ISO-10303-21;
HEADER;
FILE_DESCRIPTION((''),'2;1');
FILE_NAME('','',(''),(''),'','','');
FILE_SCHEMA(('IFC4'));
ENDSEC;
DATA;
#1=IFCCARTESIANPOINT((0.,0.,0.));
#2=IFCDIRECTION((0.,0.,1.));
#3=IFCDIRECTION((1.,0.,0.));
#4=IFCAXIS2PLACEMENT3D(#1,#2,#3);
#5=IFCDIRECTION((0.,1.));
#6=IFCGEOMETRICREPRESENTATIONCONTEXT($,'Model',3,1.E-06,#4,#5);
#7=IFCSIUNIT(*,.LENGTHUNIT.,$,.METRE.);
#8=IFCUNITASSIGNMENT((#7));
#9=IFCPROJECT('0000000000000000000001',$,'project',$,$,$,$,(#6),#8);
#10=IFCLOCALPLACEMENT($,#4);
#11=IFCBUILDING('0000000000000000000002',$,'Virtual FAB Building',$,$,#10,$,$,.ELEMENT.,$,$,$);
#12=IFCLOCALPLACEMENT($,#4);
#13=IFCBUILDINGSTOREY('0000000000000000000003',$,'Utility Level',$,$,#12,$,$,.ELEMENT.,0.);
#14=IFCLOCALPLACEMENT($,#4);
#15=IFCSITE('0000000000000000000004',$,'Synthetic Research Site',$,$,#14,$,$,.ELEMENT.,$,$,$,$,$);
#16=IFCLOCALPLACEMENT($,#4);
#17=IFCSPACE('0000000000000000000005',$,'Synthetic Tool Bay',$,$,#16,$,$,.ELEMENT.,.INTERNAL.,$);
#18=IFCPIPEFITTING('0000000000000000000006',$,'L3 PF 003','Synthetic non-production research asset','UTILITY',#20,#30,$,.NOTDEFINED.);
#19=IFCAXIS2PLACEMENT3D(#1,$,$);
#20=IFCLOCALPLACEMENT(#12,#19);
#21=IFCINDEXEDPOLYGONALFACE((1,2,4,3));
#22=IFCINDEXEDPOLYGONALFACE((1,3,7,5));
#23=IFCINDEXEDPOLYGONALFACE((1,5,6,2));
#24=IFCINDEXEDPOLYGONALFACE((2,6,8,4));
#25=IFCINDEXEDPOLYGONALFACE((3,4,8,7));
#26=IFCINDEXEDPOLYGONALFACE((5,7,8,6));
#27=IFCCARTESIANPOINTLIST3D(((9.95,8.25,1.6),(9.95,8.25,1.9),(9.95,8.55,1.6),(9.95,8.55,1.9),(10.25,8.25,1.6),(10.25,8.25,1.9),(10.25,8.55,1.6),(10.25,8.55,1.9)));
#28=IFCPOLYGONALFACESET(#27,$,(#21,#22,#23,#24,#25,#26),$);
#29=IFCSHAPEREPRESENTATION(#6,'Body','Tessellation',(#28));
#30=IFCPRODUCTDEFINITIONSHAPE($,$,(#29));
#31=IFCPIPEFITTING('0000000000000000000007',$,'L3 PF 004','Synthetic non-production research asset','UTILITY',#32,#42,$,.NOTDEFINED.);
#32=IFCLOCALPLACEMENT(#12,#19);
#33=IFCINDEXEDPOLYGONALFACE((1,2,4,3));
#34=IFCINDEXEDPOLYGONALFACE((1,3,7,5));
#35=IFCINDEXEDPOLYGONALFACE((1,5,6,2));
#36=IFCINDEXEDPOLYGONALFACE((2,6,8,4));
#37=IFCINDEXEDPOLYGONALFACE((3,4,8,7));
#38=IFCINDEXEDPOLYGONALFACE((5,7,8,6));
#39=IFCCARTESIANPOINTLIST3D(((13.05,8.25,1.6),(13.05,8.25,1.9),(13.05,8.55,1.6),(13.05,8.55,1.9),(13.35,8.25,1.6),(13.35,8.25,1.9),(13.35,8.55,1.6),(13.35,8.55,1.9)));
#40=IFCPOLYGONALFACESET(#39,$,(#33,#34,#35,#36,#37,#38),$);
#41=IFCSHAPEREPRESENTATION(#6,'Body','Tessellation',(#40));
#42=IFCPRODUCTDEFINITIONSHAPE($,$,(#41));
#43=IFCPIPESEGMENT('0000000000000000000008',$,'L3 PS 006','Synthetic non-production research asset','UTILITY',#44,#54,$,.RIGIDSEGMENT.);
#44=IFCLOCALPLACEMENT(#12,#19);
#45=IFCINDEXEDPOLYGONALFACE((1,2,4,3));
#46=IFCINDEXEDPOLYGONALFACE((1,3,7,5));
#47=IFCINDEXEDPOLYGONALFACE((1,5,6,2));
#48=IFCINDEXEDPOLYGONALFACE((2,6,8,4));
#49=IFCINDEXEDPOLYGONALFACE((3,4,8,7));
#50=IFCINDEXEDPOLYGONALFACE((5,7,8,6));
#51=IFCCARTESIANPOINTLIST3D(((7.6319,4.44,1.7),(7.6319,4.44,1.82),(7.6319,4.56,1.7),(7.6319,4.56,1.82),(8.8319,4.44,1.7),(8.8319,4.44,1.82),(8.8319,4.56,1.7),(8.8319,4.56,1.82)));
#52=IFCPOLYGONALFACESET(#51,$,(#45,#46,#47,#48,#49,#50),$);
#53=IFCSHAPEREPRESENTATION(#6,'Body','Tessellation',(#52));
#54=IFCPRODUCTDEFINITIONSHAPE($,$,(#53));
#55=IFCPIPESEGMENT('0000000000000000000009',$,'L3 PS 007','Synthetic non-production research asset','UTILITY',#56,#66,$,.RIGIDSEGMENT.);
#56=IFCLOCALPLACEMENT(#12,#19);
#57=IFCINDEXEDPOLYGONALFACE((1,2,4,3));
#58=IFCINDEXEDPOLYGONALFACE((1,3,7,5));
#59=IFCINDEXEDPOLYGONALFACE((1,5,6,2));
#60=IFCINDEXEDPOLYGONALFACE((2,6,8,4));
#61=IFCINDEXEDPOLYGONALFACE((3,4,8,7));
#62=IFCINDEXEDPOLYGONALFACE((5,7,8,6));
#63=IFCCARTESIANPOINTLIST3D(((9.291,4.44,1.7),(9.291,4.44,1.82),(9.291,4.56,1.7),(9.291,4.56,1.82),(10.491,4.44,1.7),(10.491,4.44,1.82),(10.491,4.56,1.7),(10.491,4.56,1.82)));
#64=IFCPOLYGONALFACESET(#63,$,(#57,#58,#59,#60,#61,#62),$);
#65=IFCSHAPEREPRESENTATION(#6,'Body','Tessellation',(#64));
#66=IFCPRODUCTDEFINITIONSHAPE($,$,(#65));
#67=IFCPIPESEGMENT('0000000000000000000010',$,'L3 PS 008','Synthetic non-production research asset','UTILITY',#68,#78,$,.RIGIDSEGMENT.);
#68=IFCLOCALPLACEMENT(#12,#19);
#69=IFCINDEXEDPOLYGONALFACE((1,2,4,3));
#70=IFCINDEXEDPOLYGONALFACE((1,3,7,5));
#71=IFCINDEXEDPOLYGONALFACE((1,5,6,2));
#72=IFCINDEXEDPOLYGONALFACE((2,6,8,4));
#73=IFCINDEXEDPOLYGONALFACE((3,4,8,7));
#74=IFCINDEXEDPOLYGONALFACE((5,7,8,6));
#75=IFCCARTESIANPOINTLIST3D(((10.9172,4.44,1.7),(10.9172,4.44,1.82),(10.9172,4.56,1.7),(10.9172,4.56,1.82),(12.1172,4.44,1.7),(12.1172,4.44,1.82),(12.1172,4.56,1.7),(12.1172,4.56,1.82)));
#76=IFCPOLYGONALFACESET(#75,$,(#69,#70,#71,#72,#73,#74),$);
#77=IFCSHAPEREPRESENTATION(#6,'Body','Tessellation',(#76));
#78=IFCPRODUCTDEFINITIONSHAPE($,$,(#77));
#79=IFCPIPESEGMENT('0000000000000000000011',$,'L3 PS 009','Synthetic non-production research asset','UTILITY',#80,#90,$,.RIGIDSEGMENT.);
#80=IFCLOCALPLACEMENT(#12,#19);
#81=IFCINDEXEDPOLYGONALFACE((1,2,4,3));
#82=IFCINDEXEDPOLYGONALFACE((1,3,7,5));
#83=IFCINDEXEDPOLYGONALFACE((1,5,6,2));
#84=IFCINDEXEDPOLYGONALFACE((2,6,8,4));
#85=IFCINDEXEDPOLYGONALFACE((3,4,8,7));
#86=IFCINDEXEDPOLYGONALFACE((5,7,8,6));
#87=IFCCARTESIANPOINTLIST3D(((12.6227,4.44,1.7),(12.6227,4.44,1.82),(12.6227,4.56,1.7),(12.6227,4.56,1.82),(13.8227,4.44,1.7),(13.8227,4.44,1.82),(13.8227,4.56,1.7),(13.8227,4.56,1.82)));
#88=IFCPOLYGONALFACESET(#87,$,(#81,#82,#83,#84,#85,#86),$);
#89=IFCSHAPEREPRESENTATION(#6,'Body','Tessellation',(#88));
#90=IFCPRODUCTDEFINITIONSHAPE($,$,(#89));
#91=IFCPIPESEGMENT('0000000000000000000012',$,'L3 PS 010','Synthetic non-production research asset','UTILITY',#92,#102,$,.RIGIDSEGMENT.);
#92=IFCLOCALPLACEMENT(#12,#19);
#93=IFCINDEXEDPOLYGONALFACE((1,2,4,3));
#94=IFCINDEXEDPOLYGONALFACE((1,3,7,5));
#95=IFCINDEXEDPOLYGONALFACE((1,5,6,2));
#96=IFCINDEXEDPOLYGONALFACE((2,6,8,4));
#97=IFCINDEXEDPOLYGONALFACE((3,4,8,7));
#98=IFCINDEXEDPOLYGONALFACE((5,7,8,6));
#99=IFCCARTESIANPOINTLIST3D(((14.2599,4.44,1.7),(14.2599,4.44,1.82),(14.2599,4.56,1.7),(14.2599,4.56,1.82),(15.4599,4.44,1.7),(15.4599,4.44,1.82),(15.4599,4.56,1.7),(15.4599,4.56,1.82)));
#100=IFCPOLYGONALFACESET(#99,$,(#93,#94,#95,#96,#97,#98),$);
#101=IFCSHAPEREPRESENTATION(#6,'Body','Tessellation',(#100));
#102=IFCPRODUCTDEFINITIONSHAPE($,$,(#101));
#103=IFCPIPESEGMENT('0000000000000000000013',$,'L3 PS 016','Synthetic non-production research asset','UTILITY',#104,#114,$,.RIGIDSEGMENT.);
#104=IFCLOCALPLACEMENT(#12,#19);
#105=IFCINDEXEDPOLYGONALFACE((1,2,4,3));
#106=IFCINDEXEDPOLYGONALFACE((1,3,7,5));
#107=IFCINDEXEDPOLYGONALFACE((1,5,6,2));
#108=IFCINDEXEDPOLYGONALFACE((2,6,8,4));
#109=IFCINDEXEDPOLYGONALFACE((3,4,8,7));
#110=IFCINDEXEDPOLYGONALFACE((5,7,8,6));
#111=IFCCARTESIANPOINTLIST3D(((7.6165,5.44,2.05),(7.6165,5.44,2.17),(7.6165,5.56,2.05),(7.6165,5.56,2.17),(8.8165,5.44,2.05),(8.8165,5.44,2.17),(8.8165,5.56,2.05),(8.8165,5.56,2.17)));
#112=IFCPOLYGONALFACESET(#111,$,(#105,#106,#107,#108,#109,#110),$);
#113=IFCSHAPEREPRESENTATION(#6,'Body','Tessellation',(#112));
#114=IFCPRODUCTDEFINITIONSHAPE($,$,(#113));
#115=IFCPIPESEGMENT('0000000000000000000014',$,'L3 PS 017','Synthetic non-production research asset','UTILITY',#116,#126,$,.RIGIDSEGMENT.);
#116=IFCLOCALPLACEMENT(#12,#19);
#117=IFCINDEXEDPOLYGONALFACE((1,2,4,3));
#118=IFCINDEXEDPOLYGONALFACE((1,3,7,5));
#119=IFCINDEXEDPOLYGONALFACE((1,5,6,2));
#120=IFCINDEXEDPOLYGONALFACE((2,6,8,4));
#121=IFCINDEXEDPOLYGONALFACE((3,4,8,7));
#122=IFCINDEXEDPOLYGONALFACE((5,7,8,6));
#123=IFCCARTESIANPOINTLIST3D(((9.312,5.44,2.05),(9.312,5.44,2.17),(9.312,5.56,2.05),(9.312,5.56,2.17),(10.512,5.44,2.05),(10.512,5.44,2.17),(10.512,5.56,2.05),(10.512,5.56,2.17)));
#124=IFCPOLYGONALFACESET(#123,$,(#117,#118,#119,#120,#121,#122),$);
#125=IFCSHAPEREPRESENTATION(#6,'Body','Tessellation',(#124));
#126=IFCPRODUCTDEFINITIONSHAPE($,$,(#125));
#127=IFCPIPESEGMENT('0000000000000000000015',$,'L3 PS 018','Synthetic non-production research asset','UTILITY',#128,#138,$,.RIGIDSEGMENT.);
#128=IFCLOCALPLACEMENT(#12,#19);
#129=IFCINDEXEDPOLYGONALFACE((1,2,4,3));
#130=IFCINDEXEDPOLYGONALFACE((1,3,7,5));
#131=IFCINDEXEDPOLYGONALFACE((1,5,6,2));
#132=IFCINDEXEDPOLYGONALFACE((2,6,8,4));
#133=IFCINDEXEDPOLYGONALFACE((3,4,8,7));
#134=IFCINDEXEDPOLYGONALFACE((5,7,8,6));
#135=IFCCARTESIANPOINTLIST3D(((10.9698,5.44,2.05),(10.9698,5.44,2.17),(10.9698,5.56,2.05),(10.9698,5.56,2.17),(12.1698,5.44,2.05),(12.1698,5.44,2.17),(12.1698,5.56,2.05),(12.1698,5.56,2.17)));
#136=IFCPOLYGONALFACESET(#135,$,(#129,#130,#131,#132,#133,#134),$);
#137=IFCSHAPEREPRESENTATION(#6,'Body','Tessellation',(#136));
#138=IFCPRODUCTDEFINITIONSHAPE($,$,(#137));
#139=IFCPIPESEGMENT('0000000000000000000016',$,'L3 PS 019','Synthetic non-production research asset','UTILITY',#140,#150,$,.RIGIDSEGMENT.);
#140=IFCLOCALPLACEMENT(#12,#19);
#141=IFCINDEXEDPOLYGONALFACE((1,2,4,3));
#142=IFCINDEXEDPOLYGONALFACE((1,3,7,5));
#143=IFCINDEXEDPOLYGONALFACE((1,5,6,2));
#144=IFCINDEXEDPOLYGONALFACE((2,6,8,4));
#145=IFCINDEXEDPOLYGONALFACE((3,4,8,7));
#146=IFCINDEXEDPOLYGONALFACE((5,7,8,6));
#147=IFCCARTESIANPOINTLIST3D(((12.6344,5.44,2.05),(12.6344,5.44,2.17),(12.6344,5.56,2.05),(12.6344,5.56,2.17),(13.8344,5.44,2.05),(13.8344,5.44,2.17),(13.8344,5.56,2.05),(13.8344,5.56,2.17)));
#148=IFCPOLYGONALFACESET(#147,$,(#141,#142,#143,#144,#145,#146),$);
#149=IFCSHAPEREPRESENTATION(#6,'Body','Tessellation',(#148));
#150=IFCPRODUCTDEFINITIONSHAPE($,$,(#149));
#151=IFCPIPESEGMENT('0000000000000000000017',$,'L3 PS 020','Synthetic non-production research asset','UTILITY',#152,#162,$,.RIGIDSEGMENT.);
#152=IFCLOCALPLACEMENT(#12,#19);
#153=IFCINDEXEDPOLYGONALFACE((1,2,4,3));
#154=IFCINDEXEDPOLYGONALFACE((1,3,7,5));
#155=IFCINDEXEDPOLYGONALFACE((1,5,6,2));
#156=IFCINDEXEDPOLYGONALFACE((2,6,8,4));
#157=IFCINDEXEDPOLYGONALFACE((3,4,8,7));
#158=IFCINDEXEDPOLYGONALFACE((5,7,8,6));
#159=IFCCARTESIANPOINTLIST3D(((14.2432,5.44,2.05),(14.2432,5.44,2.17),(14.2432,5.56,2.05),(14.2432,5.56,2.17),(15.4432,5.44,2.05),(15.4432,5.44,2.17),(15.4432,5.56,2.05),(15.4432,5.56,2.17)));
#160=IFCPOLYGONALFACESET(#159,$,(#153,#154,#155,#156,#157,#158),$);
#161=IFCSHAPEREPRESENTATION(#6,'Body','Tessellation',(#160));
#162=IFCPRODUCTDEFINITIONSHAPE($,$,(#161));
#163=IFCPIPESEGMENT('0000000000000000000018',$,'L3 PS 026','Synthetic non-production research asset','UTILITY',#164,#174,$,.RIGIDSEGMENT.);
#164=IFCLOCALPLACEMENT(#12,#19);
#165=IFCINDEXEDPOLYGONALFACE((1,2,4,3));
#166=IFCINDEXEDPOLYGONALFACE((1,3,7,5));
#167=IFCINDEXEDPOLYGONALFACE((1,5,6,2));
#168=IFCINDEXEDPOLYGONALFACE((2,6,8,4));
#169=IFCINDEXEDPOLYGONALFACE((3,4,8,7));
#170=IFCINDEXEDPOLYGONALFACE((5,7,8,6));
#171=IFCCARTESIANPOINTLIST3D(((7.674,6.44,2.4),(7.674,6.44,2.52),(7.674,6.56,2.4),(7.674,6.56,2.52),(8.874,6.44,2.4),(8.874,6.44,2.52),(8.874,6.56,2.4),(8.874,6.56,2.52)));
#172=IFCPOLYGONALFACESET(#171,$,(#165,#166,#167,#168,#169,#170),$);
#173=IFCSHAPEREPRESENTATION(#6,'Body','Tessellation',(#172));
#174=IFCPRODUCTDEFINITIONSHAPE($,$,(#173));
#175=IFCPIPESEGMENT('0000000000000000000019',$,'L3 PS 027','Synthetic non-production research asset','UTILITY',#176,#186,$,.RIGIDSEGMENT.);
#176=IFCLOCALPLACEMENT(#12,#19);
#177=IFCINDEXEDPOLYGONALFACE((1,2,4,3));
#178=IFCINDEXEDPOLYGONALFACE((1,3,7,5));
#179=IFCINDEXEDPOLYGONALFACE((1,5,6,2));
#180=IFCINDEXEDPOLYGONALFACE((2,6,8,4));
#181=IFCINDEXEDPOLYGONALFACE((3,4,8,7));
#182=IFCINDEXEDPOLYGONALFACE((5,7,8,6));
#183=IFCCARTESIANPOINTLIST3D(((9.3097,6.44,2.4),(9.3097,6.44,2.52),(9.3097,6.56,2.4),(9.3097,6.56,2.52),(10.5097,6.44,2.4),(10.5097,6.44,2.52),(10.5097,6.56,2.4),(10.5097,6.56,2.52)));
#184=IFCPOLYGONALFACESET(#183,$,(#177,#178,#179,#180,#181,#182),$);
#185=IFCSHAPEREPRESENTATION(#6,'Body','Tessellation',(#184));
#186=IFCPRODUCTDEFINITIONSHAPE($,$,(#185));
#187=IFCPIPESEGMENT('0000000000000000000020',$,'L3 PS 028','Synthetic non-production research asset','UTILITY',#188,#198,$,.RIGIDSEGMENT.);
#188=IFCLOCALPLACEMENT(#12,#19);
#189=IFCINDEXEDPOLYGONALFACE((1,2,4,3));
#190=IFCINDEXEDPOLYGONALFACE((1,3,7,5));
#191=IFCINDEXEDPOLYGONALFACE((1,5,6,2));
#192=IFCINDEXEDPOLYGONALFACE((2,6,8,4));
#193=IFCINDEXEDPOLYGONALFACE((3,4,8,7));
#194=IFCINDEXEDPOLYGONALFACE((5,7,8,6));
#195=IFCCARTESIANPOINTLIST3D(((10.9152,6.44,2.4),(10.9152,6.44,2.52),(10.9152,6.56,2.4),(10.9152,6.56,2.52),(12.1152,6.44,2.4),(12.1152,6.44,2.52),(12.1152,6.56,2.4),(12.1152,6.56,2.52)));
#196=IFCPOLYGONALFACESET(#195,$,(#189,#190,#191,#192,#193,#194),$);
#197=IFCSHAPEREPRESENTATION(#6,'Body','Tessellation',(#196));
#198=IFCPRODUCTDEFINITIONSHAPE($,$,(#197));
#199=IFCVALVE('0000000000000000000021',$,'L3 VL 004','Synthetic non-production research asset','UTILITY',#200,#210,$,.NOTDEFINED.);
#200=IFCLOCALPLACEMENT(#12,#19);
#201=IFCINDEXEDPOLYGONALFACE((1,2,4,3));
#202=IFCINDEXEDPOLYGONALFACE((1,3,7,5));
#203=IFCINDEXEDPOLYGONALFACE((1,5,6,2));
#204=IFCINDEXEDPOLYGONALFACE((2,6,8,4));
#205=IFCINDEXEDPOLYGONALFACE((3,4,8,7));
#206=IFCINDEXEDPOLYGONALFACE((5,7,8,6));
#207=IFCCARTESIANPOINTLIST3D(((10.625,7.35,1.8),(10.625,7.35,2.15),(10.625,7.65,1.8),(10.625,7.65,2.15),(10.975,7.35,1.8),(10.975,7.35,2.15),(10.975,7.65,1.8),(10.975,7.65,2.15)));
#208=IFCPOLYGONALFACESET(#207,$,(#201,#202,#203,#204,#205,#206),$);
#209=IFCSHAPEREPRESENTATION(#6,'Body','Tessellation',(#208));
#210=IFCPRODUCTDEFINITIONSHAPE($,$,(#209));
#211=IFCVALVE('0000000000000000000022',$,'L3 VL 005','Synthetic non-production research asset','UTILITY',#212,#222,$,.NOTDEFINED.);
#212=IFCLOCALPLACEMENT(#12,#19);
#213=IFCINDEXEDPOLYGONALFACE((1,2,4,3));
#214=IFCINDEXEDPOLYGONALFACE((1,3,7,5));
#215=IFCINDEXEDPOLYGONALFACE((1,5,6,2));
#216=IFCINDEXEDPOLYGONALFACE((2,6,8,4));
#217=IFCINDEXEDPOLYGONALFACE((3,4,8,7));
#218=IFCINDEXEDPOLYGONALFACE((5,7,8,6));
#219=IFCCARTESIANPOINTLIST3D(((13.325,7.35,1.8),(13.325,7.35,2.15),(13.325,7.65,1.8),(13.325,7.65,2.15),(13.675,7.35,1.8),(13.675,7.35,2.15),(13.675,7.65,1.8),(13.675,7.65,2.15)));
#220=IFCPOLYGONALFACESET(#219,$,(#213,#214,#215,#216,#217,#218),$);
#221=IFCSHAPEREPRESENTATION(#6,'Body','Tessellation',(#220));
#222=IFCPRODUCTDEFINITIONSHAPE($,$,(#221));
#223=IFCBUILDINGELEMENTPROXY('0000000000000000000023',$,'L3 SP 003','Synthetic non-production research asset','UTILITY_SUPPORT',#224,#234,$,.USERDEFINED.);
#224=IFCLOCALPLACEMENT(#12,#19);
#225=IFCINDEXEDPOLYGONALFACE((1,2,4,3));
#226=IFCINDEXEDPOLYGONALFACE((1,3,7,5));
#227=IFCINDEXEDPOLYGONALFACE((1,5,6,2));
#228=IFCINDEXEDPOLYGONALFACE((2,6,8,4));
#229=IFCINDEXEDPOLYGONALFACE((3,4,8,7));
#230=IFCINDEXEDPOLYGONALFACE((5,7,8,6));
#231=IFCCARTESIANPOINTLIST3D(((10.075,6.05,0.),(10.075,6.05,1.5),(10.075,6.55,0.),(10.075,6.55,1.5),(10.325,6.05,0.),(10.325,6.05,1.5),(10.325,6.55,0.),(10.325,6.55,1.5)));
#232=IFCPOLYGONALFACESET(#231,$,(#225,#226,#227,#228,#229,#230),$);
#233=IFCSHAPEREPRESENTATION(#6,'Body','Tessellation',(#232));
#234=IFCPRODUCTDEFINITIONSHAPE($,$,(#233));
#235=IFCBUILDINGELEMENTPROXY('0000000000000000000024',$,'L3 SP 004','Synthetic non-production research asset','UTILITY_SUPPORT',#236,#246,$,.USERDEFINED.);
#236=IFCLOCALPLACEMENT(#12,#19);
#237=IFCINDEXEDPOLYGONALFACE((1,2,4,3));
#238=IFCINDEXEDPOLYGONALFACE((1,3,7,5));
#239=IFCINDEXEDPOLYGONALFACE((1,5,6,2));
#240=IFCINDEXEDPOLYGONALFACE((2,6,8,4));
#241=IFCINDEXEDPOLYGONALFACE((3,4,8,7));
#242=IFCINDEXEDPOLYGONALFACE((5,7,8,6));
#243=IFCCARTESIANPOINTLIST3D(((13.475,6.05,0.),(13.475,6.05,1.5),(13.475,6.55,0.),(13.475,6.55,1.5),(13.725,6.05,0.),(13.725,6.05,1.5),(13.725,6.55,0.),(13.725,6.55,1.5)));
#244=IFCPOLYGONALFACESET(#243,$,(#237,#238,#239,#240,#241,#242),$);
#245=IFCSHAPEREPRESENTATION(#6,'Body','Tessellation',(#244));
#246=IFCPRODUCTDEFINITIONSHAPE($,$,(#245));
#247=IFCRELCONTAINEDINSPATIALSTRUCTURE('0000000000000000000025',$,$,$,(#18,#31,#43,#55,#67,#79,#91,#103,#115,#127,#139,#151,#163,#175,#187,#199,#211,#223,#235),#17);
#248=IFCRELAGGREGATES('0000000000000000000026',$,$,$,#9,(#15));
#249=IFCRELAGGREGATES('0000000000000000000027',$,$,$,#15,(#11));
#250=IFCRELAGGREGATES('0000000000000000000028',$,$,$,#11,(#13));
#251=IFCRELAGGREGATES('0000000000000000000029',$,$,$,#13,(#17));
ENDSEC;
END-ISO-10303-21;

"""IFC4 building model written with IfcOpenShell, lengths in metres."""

from ifc_helpers import new_model, si_unit, direction, frame, origin_with_axes, origin_2d_with_axis, place, context, project, spatial, rectangle, extrude, element, save


model = new_model("IFC4")

# Units and contexts
model_context = context("Model", 3, precision=1e-06, world=origin_with_axes(), true_north=direction((0.0, 1.0)))
ifc_project = project(units=[si_unit("LENGTHUNIT", "METRE")], contexts=[model_context])

# Site, building, storey, space
site_placement = place(None, origin_with_axes())
site = spatial("IfcSite", under=ifc_project, at=site_placement, Name="Synthetic Research Site", CompositionType="ELEMENT")
building_placement = place(None, origin_with_axes())
building = spatial("IfcBuilding", under=site, at=building_placement, Name="Virtual FAB Building", CompositionType="ELEMENT")
storey_placement = place(None, origin_with_axes())
storey = spatial("IfcBuildingStorey", under=building, at=storey_placement, Name="Utility Level", CompositionType="ELEMENT", Elevation=0.0)
space_placement = place(None, origin_with_axes())
space = spatial("IfcSpace", under=storey, at=space_placement, Name="Synthetic Tool Bay", CompositionType="ELEMENT", PredefinedType="INTERNAL")

# Pipe fittings
for number, where, z_axis, x_axis, name in (
    (1, (10.1, 8.4, 1.6), (0.0, 0.0, 1.0), (1.0, 0.0, 0.0), "L3 PF 003"),
    (2, (13.2, 8.4, 1.6), (0.0, 0.0, 1.0), (1.0, 0.0, 0.0), "L3 PF 004"),
):
    element("IfcPipeFitting", number, at=place(None, frame(where, z_axis=z_axis, x_axis=x_axis)), inside=space, Name=name, Description="Synthetic non-production research asset", ObjectType="UTILITY", PredefinedType="NOTDEFINED", context=model_context, shape_type="SweptSolid", body=[
        extrude(rectangle(XDim=0.3, YDim=0.3, at=origin_2d_with_axis()), origin_with_axes(), (0.0, 0.0, 1.0), 0.3),
    ])

# Pipe segments
for number, where, z_axis, x_axis, name in (
    (3, (8.2319, 4.5, 1.7), (0.0, 0.0, 1.0), (1.0, 0.0, 0.0), "L3 PS 006"),
    (4, (9.891, 4.5, 1.7), (0.0, 0.0, 1.0), (1.0, 0.0, 0.0), "L3 PS 007"),
    (5, (11.5172, 4.5, 1.7), (0.0, 0.0, 1.0), (1.0, 0.0, 0.0), "L3 PS 008"),
    (6, (13.2227, 4.5, 1.7), (0.0, 0.0, 1.0), (1.0, 0.0, 0.0), "L3 PS 009"),
    (7, (14.8599, 4.5, 1.7), (0.0, 0.0, 1.0), (1.0, 0.0, 0.0), "L3 PS 010"),
    (8, (8.2165, 5.5, 2.05), (0.0, 0.0, 1.0), (1.0, 0.0, 0.0), "L3 PS 016"),
    (9, (9.912, 5.5, 2.05), (0.0, 0.0, 1.0), (1.0, 0.0, 0.0), "L3 PS 017"),
    (10, (11.5698, 5.5, 2.05), (0.0, 0.0, 1.0), (1.0, 0.0, 0.0), "L3 PS 018"),
    (11, (13.2344, 5.5, 2.05), (0.0, 0.0, 1.0), (1.0, 0.0, 0.0), "L3 PS 019"),
    (12, (14.8432, 5.5, 2.05), (0.0, 0.0, 1.0), (1.0, 0.0, 0.0), "L3 PS 020"),
    (13, (8.274, 6.5, 2.4), (0.0, 0.0, 1.0), (1.0, 0.0, 0.0), "L3 PS 026"),
    (14, (9.9097, 6.5, 2.4), (0.0, 0.0, 1.0), (1.0, 0.0, 0.0), "L3 PS 027"),
    (15, (11.5152, 6.5, 2.4), (0.0, 0.0, 1.0), (1.0, 0.0, 0.0), "L3 PS 028"),
):
    element("IfcPipeSegment", number, at=place(None, frame(where, z_axis=z_axis, x_axis=x_axis)), inside=space, Name=name, Description="Synthetic non-production research asset", ObjectType="UTILITY", PredefinedType="RIGIDSEGMENT", context=model_context, shape_type="SweptSolid", body=[
        extrude(rectangle(XDim=1.2, YDim=0.12, at=origin_2d_with_axis()), origin_with_axes(), (0.0, 0.0, 1.0), 0.12),
    ])

# Valves
for number, where, z_axis, x_axis, name in (
    (16, (10.8, 7.5, 1.8), (0.0, 0.0, 1.0), (1.0, 0.0, 0.0), "L3 VL 004"),
    (17, (13.5, 7.5, 1.8), (0.0, 0.0, 1.0), (1.0, 0.0, 0.0), "L3 VL 005"),
):
    element("IfcValve", number, at=place(None, frame(where, z_axis=z_axis, x_axis=x_axis)), inside=space, Name=name, Description="Synthetic non-production research asset", ObjectType="UTILITY", PredefinedType="NOTDEFINED", context=model_context, shape_type="SweptSolid", body=[
        extrude(rectangle(XDim=0.35, YDim=0.3, at=origin_2d_with_axis()), origin_with_axes(), (0.0, 0.0, 1.0), 0.35),
    ])

# Building element proxies
for number, where, z_axis, x_axis, name in (
    (18, (10.2, 6.3, 0.0), (0.0, 0.0, 1.0), (1.0, 0.0, 0.0), "L3 SP 003"),
    (19, (13.6, 6.3, 0.0), (0.0, 0.0, 1.0), (1.0, 0.0, 0.0), "L3 SP 004"),
):
    element("IfcBuildingElementProxy", number, at=place(None, frame(where, z_axis=z_axis, x_axis=x_axis)), inside=space, Name=name, Description="Synthetic non-production research asset", ObjectType="UTILITY_SUPPORT", PredefinedType="USERDEFINED", context=model_context, shape_type="SweptSolid", body=[
        extrude(rectangle(XDim=0.25, YDim=0.5, at=origin_2d_with_axis()), origin_with_axes(), (0.0, 0.0, 1.0), 1.5),
    ])

save(model, "model.ifc")
